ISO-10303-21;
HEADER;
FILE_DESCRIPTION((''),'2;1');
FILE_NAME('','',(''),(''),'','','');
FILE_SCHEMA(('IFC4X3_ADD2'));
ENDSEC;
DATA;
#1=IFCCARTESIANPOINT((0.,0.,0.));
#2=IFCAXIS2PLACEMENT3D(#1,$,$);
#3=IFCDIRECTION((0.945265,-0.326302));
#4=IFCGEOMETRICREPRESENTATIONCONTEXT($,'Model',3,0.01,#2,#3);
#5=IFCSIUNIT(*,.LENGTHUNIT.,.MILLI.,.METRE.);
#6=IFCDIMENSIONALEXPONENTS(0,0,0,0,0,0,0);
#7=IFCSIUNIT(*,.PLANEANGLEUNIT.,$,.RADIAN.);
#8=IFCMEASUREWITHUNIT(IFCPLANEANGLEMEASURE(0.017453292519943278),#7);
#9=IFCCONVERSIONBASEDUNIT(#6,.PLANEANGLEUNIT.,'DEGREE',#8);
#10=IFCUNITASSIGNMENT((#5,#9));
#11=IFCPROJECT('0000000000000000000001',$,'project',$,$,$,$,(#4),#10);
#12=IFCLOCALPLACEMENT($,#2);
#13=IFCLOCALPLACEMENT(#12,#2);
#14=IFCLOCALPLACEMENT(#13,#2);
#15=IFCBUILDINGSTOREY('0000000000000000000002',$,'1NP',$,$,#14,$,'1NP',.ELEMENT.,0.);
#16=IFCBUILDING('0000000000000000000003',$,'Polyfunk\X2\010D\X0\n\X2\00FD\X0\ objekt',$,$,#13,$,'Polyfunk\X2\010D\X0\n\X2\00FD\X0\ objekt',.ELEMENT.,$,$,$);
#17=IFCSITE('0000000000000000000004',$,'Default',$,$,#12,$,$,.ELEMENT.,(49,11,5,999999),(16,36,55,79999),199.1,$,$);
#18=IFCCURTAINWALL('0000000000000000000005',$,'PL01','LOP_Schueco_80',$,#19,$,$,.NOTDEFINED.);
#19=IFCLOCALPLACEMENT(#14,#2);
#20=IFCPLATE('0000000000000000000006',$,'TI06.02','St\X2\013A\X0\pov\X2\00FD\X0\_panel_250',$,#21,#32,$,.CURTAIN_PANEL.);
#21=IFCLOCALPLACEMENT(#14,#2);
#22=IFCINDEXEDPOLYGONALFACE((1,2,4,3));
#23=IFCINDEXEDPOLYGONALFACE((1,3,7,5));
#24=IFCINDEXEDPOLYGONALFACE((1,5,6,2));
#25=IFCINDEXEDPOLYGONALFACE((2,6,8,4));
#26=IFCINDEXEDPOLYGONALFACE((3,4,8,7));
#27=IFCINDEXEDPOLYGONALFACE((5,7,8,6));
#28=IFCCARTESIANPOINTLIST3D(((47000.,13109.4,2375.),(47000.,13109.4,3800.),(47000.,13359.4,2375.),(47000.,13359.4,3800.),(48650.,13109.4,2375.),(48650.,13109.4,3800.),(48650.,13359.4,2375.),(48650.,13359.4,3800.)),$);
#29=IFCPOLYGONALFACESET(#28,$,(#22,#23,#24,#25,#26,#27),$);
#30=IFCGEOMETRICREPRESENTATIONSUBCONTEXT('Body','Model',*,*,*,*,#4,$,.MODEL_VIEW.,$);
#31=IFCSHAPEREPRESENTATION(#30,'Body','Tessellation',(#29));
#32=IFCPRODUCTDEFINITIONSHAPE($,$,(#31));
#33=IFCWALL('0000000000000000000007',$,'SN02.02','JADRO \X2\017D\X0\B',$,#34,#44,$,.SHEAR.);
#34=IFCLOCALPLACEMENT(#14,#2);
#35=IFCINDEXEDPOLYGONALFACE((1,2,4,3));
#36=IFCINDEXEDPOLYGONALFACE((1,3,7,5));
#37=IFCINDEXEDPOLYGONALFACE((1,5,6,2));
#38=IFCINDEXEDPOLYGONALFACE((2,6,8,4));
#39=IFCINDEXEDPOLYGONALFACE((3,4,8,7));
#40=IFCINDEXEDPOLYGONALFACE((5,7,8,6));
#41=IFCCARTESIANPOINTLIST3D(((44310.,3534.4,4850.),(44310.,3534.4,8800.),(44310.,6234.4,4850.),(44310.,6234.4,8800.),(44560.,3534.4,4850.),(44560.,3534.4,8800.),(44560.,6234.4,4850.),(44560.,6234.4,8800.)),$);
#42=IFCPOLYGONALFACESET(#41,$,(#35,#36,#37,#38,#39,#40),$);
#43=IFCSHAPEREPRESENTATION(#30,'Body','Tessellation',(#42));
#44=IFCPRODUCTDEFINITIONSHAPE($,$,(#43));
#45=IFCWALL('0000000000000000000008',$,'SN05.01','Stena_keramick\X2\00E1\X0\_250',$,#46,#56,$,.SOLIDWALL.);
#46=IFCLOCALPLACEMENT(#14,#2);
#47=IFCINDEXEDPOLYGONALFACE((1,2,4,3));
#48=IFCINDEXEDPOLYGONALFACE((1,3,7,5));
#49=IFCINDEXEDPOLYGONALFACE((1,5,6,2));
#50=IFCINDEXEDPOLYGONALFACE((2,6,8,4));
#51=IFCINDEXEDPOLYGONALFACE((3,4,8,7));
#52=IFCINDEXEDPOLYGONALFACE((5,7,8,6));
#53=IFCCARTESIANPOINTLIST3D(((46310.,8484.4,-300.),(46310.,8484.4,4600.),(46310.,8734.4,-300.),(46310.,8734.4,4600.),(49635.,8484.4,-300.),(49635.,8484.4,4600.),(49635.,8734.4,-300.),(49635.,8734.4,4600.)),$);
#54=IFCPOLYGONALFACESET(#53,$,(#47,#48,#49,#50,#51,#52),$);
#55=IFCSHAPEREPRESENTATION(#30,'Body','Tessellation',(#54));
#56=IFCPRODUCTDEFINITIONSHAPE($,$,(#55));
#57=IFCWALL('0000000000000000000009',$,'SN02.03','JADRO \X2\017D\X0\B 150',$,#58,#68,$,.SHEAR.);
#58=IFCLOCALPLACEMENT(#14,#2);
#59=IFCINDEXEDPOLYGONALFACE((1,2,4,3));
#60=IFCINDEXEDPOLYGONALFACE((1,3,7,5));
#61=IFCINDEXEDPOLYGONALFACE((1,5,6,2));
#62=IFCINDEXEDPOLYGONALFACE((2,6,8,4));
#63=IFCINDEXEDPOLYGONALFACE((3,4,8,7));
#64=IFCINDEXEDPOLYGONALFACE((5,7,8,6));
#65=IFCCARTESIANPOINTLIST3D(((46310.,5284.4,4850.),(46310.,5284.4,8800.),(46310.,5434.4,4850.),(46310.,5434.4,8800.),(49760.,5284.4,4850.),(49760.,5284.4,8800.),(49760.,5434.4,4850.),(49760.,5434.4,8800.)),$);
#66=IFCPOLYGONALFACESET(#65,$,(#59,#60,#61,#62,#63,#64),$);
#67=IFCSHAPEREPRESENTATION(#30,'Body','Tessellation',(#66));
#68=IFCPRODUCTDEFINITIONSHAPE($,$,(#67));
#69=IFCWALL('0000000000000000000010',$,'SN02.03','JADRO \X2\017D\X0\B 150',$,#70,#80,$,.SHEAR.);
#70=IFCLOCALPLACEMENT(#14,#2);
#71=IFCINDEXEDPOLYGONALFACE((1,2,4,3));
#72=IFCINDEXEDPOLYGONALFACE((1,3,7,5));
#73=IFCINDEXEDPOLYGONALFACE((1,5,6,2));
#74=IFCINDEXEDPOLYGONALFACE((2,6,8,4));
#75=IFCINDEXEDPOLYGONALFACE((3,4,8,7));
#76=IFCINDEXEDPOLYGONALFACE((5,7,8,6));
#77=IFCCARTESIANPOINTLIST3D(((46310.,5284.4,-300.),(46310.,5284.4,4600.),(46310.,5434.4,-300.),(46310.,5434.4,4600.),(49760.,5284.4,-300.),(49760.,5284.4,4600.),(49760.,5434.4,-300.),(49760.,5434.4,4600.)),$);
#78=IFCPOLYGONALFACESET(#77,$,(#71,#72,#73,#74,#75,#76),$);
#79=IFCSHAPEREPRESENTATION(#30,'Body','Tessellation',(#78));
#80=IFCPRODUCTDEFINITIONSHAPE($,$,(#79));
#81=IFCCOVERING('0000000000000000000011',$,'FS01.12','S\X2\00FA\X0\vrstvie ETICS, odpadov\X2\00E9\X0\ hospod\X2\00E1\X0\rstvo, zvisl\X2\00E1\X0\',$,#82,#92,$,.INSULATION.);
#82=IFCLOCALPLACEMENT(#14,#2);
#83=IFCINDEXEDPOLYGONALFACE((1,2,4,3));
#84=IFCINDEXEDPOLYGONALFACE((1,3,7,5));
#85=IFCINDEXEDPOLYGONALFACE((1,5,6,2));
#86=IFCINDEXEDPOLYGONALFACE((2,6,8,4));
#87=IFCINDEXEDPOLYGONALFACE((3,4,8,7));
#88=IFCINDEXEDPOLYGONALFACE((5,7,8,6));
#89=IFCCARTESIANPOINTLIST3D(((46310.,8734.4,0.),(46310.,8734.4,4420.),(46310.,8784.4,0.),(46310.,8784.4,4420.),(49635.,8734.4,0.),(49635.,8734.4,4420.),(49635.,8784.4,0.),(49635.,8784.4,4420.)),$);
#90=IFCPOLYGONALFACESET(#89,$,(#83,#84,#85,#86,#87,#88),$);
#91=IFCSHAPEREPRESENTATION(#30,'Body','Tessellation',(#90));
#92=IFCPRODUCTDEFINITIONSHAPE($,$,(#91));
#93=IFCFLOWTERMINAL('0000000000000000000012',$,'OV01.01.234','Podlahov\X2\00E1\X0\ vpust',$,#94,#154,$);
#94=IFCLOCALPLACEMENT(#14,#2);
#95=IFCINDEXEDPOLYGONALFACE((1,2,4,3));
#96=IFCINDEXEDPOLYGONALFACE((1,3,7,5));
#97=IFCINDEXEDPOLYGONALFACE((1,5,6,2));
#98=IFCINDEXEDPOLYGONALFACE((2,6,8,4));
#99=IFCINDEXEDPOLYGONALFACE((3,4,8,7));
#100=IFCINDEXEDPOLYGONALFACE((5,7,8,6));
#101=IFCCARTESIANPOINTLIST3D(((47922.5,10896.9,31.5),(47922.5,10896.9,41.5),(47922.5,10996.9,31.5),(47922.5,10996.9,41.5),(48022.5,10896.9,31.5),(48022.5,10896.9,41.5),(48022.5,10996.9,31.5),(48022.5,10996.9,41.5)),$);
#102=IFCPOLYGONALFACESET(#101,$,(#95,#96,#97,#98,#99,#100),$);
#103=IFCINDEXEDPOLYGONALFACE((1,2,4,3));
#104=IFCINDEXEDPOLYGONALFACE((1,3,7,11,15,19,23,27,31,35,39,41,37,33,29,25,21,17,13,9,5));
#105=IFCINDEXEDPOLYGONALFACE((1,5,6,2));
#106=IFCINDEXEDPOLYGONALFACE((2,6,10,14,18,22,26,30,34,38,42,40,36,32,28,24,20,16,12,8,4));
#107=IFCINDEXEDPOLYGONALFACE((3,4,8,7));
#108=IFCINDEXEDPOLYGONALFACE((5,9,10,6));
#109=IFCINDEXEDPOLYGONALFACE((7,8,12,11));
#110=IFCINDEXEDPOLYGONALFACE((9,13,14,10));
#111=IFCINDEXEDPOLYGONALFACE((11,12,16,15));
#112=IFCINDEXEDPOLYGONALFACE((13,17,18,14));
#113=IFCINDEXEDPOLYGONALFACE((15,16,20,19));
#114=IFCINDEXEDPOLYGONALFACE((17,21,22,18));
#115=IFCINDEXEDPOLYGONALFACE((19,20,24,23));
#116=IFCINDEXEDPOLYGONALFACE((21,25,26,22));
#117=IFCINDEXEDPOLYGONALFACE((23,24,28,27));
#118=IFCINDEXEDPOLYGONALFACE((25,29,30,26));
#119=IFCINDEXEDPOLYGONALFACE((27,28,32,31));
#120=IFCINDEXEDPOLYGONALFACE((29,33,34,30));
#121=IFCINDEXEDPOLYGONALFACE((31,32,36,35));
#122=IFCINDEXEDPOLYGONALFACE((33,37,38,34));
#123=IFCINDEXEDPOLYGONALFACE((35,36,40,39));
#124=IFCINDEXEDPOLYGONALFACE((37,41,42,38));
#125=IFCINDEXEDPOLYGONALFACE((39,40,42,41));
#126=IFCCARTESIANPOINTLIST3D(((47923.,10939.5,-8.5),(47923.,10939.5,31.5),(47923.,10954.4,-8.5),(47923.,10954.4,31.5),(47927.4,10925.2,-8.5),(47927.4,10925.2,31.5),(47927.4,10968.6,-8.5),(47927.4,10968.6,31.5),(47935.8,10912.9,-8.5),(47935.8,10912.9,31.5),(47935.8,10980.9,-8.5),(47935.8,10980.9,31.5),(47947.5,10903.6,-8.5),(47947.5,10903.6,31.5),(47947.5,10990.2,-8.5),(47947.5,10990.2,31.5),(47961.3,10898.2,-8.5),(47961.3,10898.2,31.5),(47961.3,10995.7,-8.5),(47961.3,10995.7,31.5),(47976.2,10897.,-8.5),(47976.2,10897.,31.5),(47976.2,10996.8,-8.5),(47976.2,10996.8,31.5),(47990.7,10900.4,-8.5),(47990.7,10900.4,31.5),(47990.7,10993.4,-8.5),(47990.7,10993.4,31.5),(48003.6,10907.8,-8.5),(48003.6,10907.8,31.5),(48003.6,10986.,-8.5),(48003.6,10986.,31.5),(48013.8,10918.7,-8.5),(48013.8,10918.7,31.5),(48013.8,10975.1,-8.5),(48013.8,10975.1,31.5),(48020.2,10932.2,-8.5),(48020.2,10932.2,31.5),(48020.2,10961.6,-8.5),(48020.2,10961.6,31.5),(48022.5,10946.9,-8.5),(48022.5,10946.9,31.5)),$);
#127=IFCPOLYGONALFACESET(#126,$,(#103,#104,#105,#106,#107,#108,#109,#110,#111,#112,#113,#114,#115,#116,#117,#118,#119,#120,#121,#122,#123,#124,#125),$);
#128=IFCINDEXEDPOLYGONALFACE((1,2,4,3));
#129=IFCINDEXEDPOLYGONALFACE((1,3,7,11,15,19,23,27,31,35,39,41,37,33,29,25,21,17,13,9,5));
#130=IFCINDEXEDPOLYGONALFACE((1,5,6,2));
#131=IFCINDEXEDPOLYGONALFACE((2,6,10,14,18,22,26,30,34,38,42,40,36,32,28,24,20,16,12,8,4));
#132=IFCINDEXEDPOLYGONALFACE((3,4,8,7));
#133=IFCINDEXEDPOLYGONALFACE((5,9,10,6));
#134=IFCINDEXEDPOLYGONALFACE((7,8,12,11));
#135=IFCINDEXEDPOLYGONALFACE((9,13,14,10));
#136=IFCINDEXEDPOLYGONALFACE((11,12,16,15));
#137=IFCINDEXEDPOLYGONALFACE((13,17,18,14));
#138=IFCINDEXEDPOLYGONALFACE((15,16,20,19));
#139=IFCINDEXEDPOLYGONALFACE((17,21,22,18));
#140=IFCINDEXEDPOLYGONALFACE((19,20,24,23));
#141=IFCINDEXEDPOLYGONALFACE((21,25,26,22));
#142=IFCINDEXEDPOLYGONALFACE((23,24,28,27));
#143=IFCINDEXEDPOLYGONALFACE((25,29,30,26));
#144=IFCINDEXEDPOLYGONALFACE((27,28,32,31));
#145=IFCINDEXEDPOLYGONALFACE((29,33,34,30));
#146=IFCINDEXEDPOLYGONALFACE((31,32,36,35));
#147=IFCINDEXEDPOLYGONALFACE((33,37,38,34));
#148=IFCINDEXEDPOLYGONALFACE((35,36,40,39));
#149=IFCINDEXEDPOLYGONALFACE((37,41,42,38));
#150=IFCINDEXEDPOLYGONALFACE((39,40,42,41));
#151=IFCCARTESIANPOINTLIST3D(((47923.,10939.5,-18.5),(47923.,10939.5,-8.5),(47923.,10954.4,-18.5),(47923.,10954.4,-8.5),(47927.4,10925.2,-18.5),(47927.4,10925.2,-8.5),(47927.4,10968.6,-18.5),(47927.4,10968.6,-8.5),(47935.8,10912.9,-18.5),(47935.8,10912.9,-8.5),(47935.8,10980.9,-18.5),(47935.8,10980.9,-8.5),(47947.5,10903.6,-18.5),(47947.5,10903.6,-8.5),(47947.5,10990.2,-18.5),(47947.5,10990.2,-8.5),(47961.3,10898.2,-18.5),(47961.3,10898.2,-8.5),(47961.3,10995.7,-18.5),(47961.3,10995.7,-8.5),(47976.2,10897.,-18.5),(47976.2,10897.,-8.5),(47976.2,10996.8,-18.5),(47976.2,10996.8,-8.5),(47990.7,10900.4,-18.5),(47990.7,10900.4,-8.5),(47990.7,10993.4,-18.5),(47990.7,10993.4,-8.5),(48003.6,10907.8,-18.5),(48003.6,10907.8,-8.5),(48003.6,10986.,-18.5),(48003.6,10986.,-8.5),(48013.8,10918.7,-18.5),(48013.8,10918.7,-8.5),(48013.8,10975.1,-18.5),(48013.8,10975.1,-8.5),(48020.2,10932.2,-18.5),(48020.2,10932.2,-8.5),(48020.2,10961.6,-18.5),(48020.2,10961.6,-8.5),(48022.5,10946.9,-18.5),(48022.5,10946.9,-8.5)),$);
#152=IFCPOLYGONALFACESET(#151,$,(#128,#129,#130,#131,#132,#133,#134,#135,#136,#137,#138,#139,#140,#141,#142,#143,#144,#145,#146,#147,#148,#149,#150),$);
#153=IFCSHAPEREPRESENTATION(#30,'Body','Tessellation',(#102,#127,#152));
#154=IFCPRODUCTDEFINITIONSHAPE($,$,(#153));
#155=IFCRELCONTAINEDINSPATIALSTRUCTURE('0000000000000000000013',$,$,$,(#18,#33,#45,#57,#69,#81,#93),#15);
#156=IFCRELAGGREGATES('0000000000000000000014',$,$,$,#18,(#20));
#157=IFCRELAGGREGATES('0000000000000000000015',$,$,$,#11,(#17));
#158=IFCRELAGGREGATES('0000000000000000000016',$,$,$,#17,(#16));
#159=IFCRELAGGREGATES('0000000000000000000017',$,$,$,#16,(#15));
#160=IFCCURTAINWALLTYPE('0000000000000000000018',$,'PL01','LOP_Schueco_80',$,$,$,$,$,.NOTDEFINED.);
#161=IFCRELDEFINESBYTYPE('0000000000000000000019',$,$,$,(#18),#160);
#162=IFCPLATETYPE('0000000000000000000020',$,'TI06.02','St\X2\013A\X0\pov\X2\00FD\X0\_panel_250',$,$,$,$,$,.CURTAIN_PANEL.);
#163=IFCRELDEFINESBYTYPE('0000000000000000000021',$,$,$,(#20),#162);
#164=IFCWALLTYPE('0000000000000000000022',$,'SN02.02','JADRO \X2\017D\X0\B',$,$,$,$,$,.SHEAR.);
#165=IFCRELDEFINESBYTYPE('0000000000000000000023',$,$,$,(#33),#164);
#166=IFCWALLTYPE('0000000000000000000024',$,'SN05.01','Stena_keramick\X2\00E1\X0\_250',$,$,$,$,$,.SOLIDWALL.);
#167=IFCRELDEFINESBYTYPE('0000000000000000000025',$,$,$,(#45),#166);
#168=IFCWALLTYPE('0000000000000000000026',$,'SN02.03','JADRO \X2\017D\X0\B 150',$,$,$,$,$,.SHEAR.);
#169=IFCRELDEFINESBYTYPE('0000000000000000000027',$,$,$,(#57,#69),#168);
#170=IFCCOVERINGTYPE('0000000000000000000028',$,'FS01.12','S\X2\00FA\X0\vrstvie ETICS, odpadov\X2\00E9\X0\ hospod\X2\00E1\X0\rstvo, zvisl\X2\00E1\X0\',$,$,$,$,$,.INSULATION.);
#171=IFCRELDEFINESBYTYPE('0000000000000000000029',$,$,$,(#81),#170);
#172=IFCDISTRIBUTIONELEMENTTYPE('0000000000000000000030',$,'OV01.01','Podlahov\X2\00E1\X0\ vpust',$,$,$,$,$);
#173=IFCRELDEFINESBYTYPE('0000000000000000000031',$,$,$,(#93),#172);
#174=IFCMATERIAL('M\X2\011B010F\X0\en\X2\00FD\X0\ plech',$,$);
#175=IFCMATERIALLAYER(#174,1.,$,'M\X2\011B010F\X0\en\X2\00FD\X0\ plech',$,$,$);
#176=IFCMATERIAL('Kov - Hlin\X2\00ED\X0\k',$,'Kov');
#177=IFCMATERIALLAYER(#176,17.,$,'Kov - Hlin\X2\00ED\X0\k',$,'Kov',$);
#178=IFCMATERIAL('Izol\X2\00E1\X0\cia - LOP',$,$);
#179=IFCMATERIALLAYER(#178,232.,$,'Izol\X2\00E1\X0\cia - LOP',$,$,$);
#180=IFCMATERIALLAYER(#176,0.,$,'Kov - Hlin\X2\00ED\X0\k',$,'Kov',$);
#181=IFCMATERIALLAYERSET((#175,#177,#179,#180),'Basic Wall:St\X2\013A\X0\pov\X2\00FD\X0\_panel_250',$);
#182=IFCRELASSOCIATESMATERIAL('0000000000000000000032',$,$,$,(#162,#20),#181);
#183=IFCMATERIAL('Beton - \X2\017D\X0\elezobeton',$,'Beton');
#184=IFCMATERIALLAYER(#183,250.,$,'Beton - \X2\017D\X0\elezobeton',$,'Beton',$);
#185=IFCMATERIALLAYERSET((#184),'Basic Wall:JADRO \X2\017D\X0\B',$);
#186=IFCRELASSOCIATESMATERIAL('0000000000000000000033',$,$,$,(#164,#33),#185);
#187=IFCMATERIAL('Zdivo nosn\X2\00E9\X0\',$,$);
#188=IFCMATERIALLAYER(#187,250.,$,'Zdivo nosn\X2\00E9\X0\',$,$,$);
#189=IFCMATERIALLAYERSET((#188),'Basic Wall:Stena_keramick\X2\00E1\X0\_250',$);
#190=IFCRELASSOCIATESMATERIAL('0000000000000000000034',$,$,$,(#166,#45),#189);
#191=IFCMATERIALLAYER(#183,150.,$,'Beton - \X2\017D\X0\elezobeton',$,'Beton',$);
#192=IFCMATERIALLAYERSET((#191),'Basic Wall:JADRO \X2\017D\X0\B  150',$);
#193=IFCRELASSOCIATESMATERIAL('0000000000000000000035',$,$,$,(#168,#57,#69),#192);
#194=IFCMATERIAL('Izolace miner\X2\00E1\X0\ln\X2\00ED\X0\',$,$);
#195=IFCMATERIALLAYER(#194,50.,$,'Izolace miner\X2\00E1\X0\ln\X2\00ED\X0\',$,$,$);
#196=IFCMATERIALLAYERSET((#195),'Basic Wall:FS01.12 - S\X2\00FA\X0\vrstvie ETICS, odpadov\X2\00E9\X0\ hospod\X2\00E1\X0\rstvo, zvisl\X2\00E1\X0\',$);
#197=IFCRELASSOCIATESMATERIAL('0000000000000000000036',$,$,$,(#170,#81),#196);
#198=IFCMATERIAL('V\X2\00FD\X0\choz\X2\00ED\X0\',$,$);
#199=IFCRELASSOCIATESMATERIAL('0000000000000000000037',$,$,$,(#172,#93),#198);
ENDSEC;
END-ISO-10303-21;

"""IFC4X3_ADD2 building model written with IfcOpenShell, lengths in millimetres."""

from ifc_helpers import new_model, entity, si_unit, converted_unit, direction, frame, frame_2d, origin, place, context, subcontext, project, spatial, polyline, rectangle, circle, extrude, clip, bounded_halfspace, source, transform, mapped, material, layer, layer_set, layer_usage, type_object, type_shapes, element, aggregate, save


model = new_model("IFC4X3_ADD2")

# Units and contexts
model_context = context("Model", 3, precision=0.01, world=origin(), true_north=direction((0.945265, -0.326302)))
body_context = subcontext(model_context, "Body", "Model", "MODEL_VIEW")
ifc_project = project(units=[si_unit("LENGTHUNIT", "METRE", prefix="MILLI"), converted_unit("PLANEANGLEUNIT", "DEGREE", entity("IfcPlaneAngleMeasure", 0.017453292519943278), si_unit("PLANEANGLEUNIT", "RADIAN"), dimensions=[0, 0, 0, 0, 0, 0, 0])], contexts=[model_context])

# Site, building, storey
site_placement = place(None, origin())
site = spatial("IfcSite", under=ifc_project, at=site_placement, Name="Default", CompositionType="ELEMENT", RefLatitude=(49, 11, 5, 999999), RefLongitude=(16, 36, 55, 79999), RefElevation=199.1)
building_placement = place(site_placement, origin())
building = spatial("IfcBuilding", under=site, at=building_placement, Name="Polyfunkčný objekt", LongName="Polyfunkčný objekt", CompositionType="ELEMENT")
storey_placement = place(building_placement, origin())
storey = spatial("IfcBuildingStorey", under=building, at=storey_placement, Name="1NP", LongName="1NP", CompositionType="ELEMENT", Elevation=0.0)

# Curtain wall, plate
curtain_wall_type = type_object("IfcCurtainWallType", Name="PL01", Description="LOP_Schueco_80", PredefinedType="NOTDEFINED")
curtain_wall_placement = place(storey_placement, origin())
curtain_wall = element("IfcCurtainWall", 1, at=curtain_wall_placement, inside=storey, type_object=curtain_wall_type, Name="PL01", Description="LOP_Schueco_80", PredefinedType="NOTDEFINED")
ifc_material_1 = material(Name="Měďený plech")
ifc_layer_1 = layer(ifc_material_1, 1.0, Name="Měďený plech")
ifc_material_2 = material(Name="Kov - Hliník", Category="Kov")
ifc_layer_2 = layer(ifc_material_2, 17.0, Name="Kov - Hliník", Category="Kov")
ifc_material_3 = material(Name="Izolácia - LOP")
ifc_layer_3 = layer(ifc_material_3, 232.0, Name="Izolácia - LOP")
ifc_layer_4 = layer(ifc_material_2, 0.0, Name="Kov - Hliník", Category="Kov")
ifc_layer_set_1 = layer_set([ifc_layer_1, ifc_layer_2, ifc_layer_3, ifc_layer_4], Name="Basic Wall:Stĺpový_panel_250")
ifc_layer_usage = layer_usage(ifc_layer_set_1, "AXIS2", "NEGATIVE", 125.0)
plate_type = type_object("IfcPlateType", Name="TI06.02", Description="Stĺpový_panel_250", PredefinedType="CURTAIN_PANEL", material=ifc_layer_set_1)
plate_placement = place(storey_placement, frame((47000.0, 13234.4, 2375.0)))
plate = element("IfcPlate", 2, at=plate_placement, type_object=plate_type, material=ifc_layer_usage, Name="TI06.02", Description="Stĺpový_panel_250", PredefinedType="CURTAIN_PANEL", context=body_context, shape_type="SweptSolid", body=[
    extrude(rectangle(XDim=250.0, YDim=1650.0, at=frame_2d((0.0, 0.0), x_axis=(1.0, 0.0))), frame((825.0, 0.0, 0.0), z_axis=(0.0, 0.0, 1.0), x_axis=(0.0, 1.0, 0.0)), (0.0, 0.0, 1.0), 1425.0),
])
aggregate(curtain_wall, [plate])

# Walls
ifc_material_4 = material(Name="Beton - Železobeton", Category="Beton")
ifc_layer_5 = layer(ifc_material_4, 250.0, Name="Beton - Železobeton", Category="Beton")
ifc_layer_set_2 = layer_set([ifc_layer_5], Name="Basic Wall:JADRO ŽB")
wall_type_1 = type_object("IfcWallType", Name="SN02.02", Description="JADRO ŽB", PredefinedType="SHEAR", material=ifc_layer_set_2)
wall_1_placement = place(storey_placement, frame((44435.0, 6234.4, 4850.0), z_axis=(0.0, 0.0, 1.0), x_axis=(0.0, -1.0, 0.0)))
element("IfcWall", 3, at=wall_1_placement, inside=storey, type_object=wall_type_1, material=ifc_layer_set_2, Name="SN02.02", Description="JADRO ŽB", PredefinedType="SHEAR", context=body_context, shape_type="Clipping", body=[
    clip(clip(extrude(rectangle(XDim=2700.0, YDim=250.0, at=frame_2d((1350.0, 0.0), x_axis=(-1.0, 0.0))), origin(), (0.0, 0.0, 1.0), 3950.0), bounded_halfspace(frame((2700.0, -125.0, 0.0), z_axis=(0.0, 0.0, 1.0), x_axis=(0.0, -1.0, 0.0)), True, frame((2700.0, -125.0, 0.0)), polyline([(0.0, 0.0), (0.0, 250.0), (-2700.0, 250.0), (-2700.0, 0.0), (0.0, 0.0)]))), bounded_halfspace(frame((0.0, -125.0, 3950.0), z_axis=(0.0, 0.0, -1.0), x_axis=(0.0, 1.0, 0.0)), True, frame((0.0, -125.0, 3950.0)), polyline([(0.0, 0.0), (2700.0, 0.0), (2700.0, 250.0), (0.0, 250.0), (0.0, 0.0)]))),
])
ifc_material_5 = material(Name="Zdivo nosné")
ifc_layer_6 = layer(ifc_material_5, 250.0, Name="Zdivo nosné")
ifc_layer_set_3 = layer_set([ifc_layer_6], Name="Basic Wall:Stena_keramická_250")
wall_type_2 = type_object("IfcWallType", Name="SN05.01", Description="Stena_keramická_250", PredefinedType="SOLIDWALL", material=ifc_layer_set_3)
wall_2_placement = place(storey_placement, frame((46310.0, 8609.4, -300.0)))
element("IfcWall", 4, at=wall_2_placement, inside=storey, type_object=wall_type_2, material=ifc_layer_set_3, Name="SN05.01", Description="Stena_keramická_250", PredefinedType="SOLIDWALL", context=body_context, shape_type="Clipping", body=[
    clip(clip(extrude(rectangle(XDim=3325.0, YDim=250.0, at=frame_2d((1662.5, 0.0), x_axis=(-1.0, 0.0))), origin(), (0.0, 0.0, 1.0), 4900.0), bounded_halfspace(frame((0.0, -125.0, 4900.0), z_axis=(0.0, 0.0, -1.0), x_axis=(1.0, 0.0, 0.0)), True, frame((0.0, -125.0, 4900.0)), polyline([(0.0, 0.0), (3325.0, 0.0), (3325.0, 250.0), (0.0, 250.0), (0.0, 0.0)]))), bounded_halfspace(frame((3325.0, -125.0, 0.0), z_axis=(0.0, 0.0, 1.0), x_axis=(0.0, 1.0, 0.0)), True, frame((3325.0, -125.0, 0.0)), polyline([(0.0, 0.0), (0.0, 250.0), (-3325.0, 250.0), (-3325.0, 0.0), (0.0, 0.0)]))),
])
ifc_layer_7 = layer(ifc_material_4, 150.0, Name="Beton - Železobeton", Category="Beton")
ifc_layer_set_4 = layer_set([ifc_layer_7], Name="Basic Wall:JADRO ŽB  150")
wall_type_3 = type_object("IfcWallType", Name="SN02.03", Description="JADRO ŽB 150", PredefinedType="SHEAR", material=ifc_layer_set_4)
wall_3_placement = place(storey_placement, frame((46310.0, 5359.4, 4850.0)))
element("IfcWall", 5, at=wall_3_placement, inside=storey, type_object=wall_type_3, material=ifc_layer_set_4, Name="SN02.03", Description="JADRO ŽB 150", PredefinedType="SHEAR", context=body_context, shape_type="SweptSolid", body=[
    extrude(rectangle(XDim=3450.0, YDim=150.0, at=frame_2d((1725.0, 0.0), x_axis=(-1.0, 0.0))), origin(), (0.0, 0.0, 1.0), 3950.0),
])
wall_4_placement = place(storey_placement, frame((46310.0, 5359.4, -300.0)))
element("IfcWall", 6, at=wall_4_placement, inside=storey, type_object=wall_type_3, material=ifc_layer_set_4, Name="SN02.03", Description="JADRO ŽB 150", PredefinedType="SHEAR", context=body_context, shape_type="SweptSolid", body=[
    extrude(rectangle(XDim=3450.0, YDim=150.0, at=frame_2d((1725.0, 0.0), x_axis=(-1.0, 0.0))), origin(), (0.0, 0.0, 1.0), 4900.0),
])

# Covering
ifc_material_6 = material(Name="Izolace minerální")
ifc_layer_8 = layer(ifc_material_6, 50.0, Name="Izolace minerální")
ifc_layer_set_5 = layer_set([ifc_layer_8], Name="Basic Wall:FS01.12 - Súvrstvie ETICS, odpadové hospodárstvo, zvislá")
covering_type = type_object("IfcCoveringType", Name="FS01.12", Description="Súvrstvie ETICS, odpadové hospodárstvo, zvislá", PredefinedType="INSULATION", material=ifc_layer_set_5)
covering_placement = place(storey_placement, frame((46310.0, 8759.4, 0.0)))
element("IfcCovering", 7, at=covering_placement, inside=storey, type_object=covering_type, material=ifc_layer_set_5, Name="FS01.12", Description="Súvrstvie ETICS, odpadové hospodárstvo, zvislá", PredefinedType="INSULATION", context=body_context, shape_type="SweptSolid", body=[
    extrude(rectangle(XDim=3325.0, YDim=50.0, at=frame_2d((1662.5, 0.0), x_axis=(-1.0, 0.0))), origin(), (0.0, 0.0, 1.0), 4420.0),
])

# Flow terminal
ifc_material_7 = material(Name="Výchozí")
distribution_element_type = type_object("IfcDistributionElementType", Name="OV01.01", Description="Podlahová vpust", material=ifc_material_7)
shared_shape_1 = source(origin(), body_context, "Body", "SweptSolid", [
    extrude(rectangle(XDim=100.0, YDim=100.0, at=frame_2d((0.0, 0.0), x_axis=(1.0, 0.0))), frame((0.0, 0.0, -10.0), z_axis=(0.0, 0.0, 1.0), x_axis=(-1.0, 0.0, 0.0)), (0.0, 0.0, 1.0), 10.0),
    extrude(circle(Radius=50.0, at=frame_2d((0.0, 0.0), x_axis=(1.0, 0.0))), frame((0.0, 0.0, -50.0)), (0.0, 0.0, 1.0), 40.0),
    extrude(circle(Radius=50.0, at=frame_2d((0.0, 0.0), x_axis=(1.0, 0.0))), frame((0.0, 0.0, -60.0)), (0.0, 0.0, 1.0), 10.0),
])
type_shapes(distribution_element_type, [shared_shape_1])
flow_terminal_placement = place(storey_placement, frame((47972.5, 10946.9, 41.5)))
element("IfcFlowTerminal", 8, at=flow_terminal_placement, inside=storey, type_object=distribution_element_type, material=ifc_material_7, Name="OV01.01.234", Description="Podlahová vpust", context=body_context, shape_type="MappedRepresentation", body=[
    mapped(shared_shape_1, transform((0.0, 0.0, 0.0), scale=1.0)),
])

save(model, "model.ifc")
